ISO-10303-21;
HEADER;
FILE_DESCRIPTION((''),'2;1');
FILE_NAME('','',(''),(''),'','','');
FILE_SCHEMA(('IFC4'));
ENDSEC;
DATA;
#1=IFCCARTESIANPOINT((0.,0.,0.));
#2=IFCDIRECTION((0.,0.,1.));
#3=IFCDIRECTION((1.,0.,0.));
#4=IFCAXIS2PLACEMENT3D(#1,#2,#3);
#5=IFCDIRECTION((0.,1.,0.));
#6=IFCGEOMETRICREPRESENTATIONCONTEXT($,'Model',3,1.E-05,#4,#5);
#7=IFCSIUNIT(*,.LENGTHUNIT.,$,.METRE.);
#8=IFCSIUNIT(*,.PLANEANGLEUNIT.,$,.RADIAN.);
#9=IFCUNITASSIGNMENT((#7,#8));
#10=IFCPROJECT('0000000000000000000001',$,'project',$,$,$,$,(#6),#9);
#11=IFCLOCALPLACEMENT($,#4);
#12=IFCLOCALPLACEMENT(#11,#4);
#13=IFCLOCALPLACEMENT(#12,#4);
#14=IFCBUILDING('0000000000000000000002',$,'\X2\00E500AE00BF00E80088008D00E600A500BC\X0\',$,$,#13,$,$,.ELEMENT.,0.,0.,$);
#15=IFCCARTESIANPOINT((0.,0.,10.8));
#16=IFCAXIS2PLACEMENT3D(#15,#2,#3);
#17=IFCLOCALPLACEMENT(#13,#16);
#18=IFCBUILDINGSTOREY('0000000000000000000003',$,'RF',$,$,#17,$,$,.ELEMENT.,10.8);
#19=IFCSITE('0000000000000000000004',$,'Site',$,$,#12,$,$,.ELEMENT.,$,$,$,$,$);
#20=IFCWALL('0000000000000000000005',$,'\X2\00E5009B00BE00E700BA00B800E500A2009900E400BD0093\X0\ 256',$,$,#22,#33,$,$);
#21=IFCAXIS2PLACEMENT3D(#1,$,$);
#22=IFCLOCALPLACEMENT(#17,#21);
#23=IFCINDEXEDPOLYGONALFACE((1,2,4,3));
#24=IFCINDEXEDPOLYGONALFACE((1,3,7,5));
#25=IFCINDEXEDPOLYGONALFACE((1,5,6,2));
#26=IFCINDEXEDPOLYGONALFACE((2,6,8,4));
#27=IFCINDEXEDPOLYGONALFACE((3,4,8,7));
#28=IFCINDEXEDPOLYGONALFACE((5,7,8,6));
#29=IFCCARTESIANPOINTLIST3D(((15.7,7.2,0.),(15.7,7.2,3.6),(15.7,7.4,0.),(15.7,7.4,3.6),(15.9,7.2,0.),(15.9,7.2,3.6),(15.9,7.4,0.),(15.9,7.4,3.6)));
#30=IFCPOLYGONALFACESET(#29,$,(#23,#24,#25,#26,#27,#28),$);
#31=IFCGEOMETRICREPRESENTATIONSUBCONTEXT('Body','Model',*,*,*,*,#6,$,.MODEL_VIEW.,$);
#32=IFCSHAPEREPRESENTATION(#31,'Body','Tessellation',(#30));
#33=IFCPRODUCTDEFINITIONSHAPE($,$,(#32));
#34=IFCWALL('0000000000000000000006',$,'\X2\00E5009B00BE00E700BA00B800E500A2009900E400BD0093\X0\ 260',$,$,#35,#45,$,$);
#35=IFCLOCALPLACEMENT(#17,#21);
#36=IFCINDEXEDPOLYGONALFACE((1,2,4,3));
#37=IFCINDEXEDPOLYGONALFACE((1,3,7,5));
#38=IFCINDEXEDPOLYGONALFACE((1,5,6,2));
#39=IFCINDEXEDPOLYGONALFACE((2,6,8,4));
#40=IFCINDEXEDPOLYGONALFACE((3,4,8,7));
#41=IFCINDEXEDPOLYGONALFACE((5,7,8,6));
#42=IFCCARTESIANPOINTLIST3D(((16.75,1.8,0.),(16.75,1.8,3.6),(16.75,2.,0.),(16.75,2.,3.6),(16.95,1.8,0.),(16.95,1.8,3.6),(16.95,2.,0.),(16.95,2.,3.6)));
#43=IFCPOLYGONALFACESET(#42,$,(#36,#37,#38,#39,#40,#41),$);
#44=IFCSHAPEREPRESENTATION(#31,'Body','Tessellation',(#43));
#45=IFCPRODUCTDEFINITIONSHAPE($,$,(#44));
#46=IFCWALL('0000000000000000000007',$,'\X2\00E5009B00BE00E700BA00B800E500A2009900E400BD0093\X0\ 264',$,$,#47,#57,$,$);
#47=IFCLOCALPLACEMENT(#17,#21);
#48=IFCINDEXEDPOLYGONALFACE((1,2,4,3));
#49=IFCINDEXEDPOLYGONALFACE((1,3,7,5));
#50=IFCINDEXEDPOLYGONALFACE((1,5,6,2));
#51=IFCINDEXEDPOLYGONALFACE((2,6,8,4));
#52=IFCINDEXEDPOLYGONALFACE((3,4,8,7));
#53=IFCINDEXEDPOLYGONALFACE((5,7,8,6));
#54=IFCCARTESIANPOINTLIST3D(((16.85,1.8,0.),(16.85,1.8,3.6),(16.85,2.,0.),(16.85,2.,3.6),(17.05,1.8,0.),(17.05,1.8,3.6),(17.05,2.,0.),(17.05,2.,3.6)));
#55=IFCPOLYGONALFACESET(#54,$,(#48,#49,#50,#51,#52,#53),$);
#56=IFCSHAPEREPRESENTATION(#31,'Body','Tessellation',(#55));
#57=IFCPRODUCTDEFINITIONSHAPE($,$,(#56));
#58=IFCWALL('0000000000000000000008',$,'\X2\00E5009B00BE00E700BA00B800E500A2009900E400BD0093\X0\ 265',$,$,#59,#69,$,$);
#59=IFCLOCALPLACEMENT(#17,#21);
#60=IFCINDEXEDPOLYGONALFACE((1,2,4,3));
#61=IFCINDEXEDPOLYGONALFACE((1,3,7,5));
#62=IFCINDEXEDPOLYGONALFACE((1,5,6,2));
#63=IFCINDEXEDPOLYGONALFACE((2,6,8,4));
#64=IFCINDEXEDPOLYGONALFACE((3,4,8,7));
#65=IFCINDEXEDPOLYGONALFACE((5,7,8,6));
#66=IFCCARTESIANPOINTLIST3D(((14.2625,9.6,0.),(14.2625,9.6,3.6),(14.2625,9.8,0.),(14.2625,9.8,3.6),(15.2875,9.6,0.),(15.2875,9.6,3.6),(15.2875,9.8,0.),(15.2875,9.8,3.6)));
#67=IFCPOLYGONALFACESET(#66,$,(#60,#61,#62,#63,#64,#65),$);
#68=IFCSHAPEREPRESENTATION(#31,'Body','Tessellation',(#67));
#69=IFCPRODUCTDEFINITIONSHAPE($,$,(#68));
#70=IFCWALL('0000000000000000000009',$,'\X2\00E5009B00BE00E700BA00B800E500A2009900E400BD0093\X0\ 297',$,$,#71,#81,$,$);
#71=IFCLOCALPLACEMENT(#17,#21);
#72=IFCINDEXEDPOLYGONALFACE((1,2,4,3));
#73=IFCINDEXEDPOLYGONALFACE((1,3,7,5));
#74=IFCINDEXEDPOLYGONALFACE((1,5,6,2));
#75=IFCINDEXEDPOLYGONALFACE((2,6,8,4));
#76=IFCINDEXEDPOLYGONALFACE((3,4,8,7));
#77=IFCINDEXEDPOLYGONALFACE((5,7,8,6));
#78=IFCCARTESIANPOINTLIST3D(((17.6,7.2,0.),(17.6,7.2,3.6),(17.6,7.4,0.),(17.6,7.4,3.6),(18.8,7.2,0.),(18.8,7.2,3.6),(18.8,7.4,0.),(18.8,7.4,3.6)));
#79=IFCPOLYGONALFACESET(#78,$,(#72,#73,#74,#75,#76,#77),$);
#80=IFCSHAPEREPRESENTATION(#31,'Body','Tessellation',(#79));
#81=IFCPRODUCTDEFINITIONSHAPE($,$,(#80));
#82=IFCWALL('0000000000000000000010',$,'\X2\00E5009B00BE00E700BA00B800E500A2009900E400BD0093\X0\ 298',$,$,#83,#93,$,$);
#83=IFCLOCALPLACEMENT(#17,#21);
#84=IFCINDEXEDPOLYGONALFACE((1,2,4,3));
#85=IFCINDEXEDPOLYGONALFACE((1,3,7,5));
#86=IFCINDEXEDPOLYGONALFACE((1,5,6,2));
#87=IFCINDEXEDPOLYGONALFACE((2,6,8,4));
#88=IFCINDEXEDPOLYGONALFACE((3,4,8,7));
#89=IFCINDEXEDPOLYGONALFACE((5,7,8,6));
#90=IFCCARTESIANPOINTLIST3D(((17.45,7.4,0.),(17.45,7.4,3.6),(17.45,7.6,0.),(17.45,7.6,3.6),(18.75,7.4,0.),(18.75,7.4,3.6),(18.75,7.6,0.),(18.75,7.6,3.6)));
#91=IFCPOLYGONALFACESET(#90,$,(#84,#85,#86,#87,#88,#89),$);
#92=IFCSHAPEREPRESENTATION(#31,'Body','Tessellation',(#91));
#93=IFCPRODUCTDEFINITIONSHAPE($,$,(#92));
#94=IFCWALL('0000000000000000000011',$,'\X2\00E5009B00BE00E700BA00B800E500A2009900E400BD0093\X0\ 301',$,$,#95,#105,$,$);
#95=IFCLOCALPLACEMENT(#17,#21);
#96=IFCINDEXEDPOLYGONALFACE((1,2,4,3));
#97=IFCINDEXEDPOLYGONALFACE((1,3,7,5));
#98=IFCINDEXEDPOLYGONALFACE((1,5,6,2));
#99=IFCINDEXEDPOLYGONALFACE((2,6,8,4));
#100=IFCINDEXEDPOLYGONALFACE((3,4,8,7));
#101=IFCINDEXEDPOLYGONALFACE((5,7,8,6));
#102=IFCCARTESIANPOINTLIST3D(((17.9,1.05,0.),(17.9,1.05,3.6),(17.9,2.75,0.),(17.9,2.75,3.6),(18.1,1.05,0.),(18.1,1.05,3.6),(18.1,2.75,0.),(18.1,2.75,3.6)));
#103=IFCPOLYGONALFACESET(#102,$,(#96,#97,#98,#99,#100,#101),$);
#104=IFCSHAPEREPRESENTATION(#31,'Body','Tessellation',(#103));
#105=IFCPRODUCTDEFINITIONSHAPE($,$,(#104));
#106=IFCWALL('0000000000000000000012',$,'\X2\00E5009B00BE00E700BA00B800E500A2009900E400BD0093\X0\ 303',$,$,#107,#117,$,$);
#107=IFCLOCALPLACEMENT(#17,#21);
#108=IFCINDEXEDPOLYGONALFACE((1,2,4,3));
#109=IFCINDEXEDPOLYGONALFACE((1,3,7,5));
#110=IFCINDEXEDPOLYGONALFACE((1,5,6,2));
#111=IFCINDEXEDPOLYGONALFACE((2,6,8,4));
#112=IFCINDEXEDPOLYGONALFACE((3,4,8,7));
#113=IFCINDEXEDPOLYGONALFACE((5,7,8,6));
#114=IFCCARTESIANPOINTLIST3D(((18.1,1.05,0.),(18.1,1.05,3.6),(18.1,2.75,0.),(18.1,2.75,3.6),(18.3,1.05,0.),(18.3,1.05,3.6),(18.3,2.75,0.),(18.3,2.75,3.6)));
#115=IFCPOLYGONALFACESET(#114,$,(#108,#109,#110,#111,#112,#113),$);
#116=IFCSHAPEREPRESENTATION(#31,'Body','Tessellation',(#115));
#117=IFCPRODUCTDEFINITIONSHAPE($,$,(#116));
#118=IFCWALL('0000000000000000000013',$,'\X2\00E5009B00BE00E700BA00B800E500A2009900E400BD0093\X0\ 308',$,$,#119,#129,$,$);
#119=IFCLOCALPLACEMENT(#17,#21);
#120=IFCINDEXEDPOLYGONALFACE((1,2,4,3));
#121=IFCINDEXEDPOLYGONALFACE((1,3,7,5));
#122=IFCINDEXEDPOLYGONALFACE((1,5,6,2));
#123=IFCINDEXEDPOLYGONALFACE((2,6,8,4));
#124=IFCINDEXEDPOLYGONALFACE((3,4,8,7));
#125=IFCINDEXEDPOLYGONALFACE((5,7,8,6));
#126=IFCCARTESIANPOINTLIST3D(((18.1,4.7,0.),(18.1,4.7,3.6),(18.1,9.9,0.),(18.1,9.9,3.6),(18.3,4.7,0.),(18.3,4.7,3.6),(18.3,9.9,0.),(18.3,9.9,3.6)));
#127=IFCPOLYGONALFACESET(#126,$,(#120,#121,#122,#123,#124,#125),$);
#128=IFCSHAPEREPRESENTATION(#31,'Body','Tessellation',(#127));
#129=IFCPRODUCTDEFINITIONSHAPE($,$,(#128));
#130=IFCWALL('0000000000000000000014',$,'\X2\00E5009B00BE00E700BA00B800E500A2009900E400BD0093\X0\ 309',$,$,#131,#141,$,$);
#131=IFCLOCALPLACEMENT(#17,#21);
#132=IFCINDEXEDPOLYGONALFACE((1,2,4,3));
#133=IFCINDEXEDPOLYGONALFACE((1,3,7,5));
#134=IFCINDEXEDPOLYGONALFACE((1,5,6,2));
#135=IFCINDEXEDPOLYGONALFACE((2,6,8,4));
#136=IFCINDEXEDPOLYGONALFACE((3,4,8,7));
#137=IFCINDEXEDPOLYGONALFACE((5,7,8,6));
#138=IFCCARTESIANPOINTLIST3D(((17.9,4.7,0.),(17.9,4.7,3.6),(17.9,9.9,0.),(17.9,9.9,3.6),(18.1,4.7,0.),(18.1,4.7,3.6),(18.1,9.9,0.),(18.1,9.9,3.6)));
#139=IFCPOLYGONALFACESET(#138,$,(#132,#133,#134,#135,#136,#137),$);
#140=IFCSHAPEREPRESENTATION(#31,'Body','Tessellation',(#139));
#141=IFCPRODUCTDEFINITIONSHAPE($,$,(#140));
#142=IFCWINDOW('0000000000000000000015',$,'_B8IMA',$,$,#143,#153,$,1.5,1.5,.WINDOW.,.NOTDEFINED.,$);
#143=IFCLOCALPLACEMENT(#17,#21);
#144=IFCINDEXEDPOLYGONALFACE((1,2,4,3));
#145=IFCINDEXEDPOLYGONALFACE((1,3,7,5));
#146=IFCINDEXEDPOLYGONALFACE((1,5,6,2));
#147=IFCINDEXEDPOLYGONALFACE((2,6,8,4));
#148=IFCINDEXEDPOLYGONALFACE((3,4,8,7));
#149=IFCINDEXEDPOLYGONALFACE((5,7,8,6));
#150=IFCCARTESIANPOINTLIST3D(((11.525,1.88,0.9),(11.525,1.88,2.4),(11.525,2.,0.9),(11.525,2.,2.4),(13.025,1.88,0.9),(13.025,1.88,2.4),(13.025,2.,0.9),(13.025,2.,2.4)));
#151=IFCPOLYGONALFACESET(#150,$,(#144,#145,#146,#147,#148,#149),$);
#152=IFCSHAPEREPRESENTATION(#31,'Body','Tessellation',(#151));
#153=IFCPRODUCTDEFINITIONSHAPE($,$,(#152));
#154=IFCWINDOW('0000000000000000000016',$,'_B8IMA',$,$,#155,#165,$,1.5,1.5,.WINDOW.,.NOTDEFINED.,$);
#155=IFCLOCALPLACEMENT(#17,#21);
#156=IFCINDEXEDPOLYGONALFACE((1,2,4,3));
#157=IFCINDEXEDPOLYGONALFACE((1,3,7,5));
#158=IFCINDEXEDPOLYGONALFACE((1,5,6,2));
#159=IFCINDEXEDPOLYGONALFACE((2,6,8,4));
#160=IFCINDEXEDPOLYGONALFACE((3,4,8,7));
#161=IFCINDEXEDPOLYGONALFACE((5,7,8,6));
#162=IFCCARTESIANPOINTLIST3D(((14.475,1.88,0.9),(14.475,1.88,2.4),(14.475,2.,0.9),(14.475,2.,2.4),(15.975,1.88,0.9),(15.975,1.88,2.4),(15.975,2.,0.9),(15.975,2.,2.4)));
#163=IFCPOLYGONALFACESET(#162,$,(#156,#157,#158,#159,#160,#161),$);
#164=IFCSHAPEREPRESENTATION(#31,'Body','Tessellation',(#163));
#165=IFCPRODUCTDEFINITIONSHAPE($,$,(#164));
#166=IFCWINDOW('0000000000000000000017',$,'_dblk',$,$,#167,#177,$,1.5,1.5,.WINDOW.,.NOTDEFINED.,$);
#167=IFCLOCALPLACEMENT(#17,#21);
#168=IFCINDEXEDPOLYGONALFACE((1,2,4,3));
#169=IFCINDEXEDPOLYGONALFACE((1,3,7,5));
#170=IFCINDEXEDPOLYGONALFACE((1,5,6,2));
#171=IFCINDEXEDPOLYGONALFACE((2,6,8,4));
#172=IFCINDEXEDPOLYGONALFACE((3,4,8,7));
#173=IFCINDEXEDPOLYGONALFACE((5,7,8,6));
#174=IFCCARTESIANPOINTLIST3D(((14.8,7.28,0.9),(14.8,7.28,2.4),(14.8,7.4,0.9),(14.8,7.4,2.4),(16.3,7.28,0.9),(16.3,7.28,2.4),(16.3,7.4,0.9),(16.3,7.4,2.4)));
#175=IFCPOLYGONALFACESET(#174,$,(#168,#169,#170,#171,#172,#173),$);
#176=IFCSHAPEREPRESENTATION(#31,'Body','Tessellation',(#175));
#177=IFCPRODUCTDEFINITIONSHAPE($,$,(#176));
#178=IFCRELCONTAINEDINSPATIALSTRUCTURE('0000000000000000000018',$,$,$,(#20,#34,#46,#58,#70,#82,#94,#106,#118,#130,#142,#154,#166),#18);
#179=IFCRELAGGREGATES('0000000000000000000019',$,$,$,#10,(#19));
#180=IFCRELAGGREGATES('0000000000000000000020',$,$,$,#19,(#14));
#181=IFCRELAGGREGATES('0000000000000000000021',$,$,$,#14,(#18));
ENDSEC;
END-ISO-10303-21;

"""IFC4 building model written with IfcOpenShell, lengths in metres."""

from ifc_helpers import new_model, si_unit, direction, frame, frame_2d, origin_with_axes, place, context, subcontext, project, spatial, rectangle, extrude, element, save


model = new_model("IFC4")

# Units and contexts
model_context = context("Model", 3, precision=1e-05, world=origin_with_axes(), true_north=direction((0.0, 1.0, 0.0)))
body_context = subcontext(model_context, "Body", "Model", "MODEL_VIEW")
ifc_project = project(units=[si_unit("LENGTHUNIT", "METRE"), si_unit("PLANEANGLEUNIT", "RADIAN")], contexts=[model_context])

# Site, building, storey
placement = place(None, origin_with_axes())
site_placement = place(placement, origin_with_axes())
site = spatial("IfcSite", under=ifc_project, at=site_placement, Name="Site", CompositionType="ELEMENT")
building_placement = place(site_placement, origin_with_axes())
building = spatial("IfcBuilding", under=site, at=building_placement, Name="å®¿è\u0088\u008dæ¥¼", CompositionType="ELEMENT", ElevationOfRefHeight=0.0, ElevationOfTerrain=0.0)
storey_placement = place(building_placement, frame((0.0, 0.0, 10.8), z_axis=(0.0, 0.0, 1.0), x_axis=(1.0, 0.0, 0.0)))
storey = spatial("IfcBuildingStorey", under=building, at=storey_placement, Name="RF", CompositionType="ELEMENT", Elevation=10.8)

# Walls
for number, where, z_axis, x_axis, name in (
    (1, (15.8, 7.3, 0.0), (0.0, 0.0, 1.0), (0.0, 1.0, 0.0), "å\u009b¾çº¸å¢\u0099ä½\u0093 256"),
    (2, (16.85, 1.9, 0.0), (0.0, 0.0, 1.0), (0.0, 1.0, 0.0), "å\u009b¾çº¸å¢\u0099ä½\u0093 260"),
    (3, (16.95, 1.9, 0.0), (0.0, 0.0, 1.0), (0.0, -1.0, 0.0), "å\u009b¾çº¸å¢\u0099ä½\u0093 264"),
):
    element("IfcWall", number, at=place(storey_placement, frame(where, z_axis=z_axis, x_axis=x_axis)), inside=storey, Name=name, context=body_context, shape_type="SweptSolid", body=[
        extrude(rectangle(XDim=0.2, YDim=0.2, at=frame_2d((0.0, 0.0), x_axis=(1.0, 0.0, 0.0))), frame((0.0, 0.0, 0.0), z_axis=(0.0, 0.0, 1.0)), (0.0, 0.0, 1.0), 3.6),
    ])
wall_1_placement = place(storey_placement, frame((14.775, 9.7, 0.0), z_axis=(0.0, 0.0, 1.0), x_axis=(1.0, 0.0, 0.0)))
element("IfcWall", 4, at=wall_1_placement, inside=storey, Name="å\u009b¾çº¸å¢\u0099ä½\u0093 265", context=body_context, shape_type="SweptSolid", body=[
    extrude(rectangle(XDim=1.025, YDim=0.2, at=frame_2d((0.0, 0.0), x_axis=(1.0, 0.0, 0.0))), frame((0.0, 0.0, 0.0), z_axis=(0.0, 0.0, 1.0)), (0.0, 0.0, 1.0), 3.6),
])
wall_2_placement = place(storey_placement, frame((18.2, 7.3, 0.0), z_axis=(0.0, 0.0, 1.0), x_axis=(1.0, 0.0, 0.0)))
element("IfcWall", 5, at=wall_2_placement, inside=storey, Name="å\u009b¾çº¸å¢\u0099ä½\u0093 297", context=body_context, shape_type="SweptSolid", body=[
    extrude(rectangle(XDim=1.2, YDim=0.2, at=frame_2d((0.0, 0.0), x_axis=(1.0, 0.0, 0.0))), frame((0.0, 0.0, 0.0), z_axis=(0.0, 0.0, 1.0)), (0.0, 0.0, 1.0), 3.6),
])
wall_3_placement = place(storey_placement, frame((18.1, 7.5, 0.0), z_axis=(0.0, 0.0, 1.0), x_axis=(1.0, 0.0, 0.0)))
element("IfcWall", 6, at=wall_3_placement, inside=storey, Name="å\u009b¾çº¸å¢\u0099ä½\u0093 298", context=body_context, shape_type="SweptSolid", body=[
    extrude(rectangle(XDim=1.3, YDim=0.2, at=frame_2d((0.0, 0.0), x_axis=(1.0, 0.0, 0.0))), frame((0.0, 0.0, 0.0), z_axis=(0.0, 0.0, 1.0)), (0.0, 0.0, 1.0), 3.6),
])
for number, where, z_axis, x_axis, name in (
    (7, (18.0, 1.9, 0.0), (0.0, 0.0, 1.0), (0.0, -1.0, 0.0), "å\u009b¾çº¸å¢\u0099ä½\u0093 301"),
    (8, (18.2, 1.9, 0.0), (0.0, 0.0, 1.0), (0.0, -1.0, 0.0), "å\u009b¾çº¸å¢\u0099ä½\u0093 303"),
):
    element("IfcWall", number, at=place(storey_placement, frame(where, z_axis=z_axis, x_axis=x_axis)), inside=storey, Name=name, context=body_context, shape_type="SweptSolid", body=[
        extrude(rectangle(XDim=1.7, YDim=0.2, at=frame_2d((0.0, 0.0), x_axis=(1.0, 0.0, 0.0))), frame((0.0, 0.0, 0.0), z_axis=(0.0, 0.0, 1.0)), (0.0, 0.0, 1.0), 3.6),
    ])
for number, where, z_axis, x_axis, name in (
    (9, (18.2, 7.3, 0.0), (0.0, 0.0, 1.0), (0.0, -1.0, 0.0), "å\u009b¾çº¸å¢\u0099ä½\u0093 308"),
    (10, (18.0, 7.3, 0.0), (0.0, 0.0, 1.0), (0.0, -1.0, 0.0), "å\u009b¾çº¸å¢\u0099ä½\u0093 309"),
):
    element("IfcWall", number, at=place(storey_placement, frame(where, z_axis=z_axis, x_axis=x_axis)), inside=storey, Name=name, context=body_context, shape_type="SweptSolid", body=[
        extrude(rectangle(XDim=5.2, YDim=0.2, at=frame_2d((0.0, 0.0), x_axis=(1.0, 0.0, 0.0))), frame((0.0, 0.0, 0.0), z_axis=(0.0, 0.0, 1.0)), (0.0, 0.0, 1.0), 3.6),
    ])

# Windows
for number, where, z_axis, x_axis, name in (
    (11, (12.275, 1.94, 0.9), (0.0, 0.0, 1.0), (1.0, 0.0, 0.0), "_B8IMA"),
    (12, (15.225, 1.94, 0.9), (0.0, 0.0, 1.0), (1.0, 0.0, 0.0), "_B8IMA"),
    (13, (15.55, 7.34, 0.9), (0.0, 0.0, 1.0), (1.0, 0.0, 0.0), "_dblk"),
):
    element("IfcWindow", number, at=place(storey_placement, frame(where, z_axis=z_axis, x_axis=x_axis)), inside=storey, Name=name, OverallHeight=1.5, OverallWidth=1.5, PartitioningType="NOTDEFINED", PredefinedType="WINDOW", context=body_context, shape_type="SweptSolid", body=[
        extrude(rectangle(XDim=1.5, YDim=0.12, at=frame_2d((0.0, 0.0), x_axis=(1.0, 0.0, 0.0))), frame((0.0, 0.0, 0.0), z_axis=(0.0, 0.0, 1.0)), (0.0, 0.0, 1.0), 1.5),
    ])

save(model, "model.ifc")
